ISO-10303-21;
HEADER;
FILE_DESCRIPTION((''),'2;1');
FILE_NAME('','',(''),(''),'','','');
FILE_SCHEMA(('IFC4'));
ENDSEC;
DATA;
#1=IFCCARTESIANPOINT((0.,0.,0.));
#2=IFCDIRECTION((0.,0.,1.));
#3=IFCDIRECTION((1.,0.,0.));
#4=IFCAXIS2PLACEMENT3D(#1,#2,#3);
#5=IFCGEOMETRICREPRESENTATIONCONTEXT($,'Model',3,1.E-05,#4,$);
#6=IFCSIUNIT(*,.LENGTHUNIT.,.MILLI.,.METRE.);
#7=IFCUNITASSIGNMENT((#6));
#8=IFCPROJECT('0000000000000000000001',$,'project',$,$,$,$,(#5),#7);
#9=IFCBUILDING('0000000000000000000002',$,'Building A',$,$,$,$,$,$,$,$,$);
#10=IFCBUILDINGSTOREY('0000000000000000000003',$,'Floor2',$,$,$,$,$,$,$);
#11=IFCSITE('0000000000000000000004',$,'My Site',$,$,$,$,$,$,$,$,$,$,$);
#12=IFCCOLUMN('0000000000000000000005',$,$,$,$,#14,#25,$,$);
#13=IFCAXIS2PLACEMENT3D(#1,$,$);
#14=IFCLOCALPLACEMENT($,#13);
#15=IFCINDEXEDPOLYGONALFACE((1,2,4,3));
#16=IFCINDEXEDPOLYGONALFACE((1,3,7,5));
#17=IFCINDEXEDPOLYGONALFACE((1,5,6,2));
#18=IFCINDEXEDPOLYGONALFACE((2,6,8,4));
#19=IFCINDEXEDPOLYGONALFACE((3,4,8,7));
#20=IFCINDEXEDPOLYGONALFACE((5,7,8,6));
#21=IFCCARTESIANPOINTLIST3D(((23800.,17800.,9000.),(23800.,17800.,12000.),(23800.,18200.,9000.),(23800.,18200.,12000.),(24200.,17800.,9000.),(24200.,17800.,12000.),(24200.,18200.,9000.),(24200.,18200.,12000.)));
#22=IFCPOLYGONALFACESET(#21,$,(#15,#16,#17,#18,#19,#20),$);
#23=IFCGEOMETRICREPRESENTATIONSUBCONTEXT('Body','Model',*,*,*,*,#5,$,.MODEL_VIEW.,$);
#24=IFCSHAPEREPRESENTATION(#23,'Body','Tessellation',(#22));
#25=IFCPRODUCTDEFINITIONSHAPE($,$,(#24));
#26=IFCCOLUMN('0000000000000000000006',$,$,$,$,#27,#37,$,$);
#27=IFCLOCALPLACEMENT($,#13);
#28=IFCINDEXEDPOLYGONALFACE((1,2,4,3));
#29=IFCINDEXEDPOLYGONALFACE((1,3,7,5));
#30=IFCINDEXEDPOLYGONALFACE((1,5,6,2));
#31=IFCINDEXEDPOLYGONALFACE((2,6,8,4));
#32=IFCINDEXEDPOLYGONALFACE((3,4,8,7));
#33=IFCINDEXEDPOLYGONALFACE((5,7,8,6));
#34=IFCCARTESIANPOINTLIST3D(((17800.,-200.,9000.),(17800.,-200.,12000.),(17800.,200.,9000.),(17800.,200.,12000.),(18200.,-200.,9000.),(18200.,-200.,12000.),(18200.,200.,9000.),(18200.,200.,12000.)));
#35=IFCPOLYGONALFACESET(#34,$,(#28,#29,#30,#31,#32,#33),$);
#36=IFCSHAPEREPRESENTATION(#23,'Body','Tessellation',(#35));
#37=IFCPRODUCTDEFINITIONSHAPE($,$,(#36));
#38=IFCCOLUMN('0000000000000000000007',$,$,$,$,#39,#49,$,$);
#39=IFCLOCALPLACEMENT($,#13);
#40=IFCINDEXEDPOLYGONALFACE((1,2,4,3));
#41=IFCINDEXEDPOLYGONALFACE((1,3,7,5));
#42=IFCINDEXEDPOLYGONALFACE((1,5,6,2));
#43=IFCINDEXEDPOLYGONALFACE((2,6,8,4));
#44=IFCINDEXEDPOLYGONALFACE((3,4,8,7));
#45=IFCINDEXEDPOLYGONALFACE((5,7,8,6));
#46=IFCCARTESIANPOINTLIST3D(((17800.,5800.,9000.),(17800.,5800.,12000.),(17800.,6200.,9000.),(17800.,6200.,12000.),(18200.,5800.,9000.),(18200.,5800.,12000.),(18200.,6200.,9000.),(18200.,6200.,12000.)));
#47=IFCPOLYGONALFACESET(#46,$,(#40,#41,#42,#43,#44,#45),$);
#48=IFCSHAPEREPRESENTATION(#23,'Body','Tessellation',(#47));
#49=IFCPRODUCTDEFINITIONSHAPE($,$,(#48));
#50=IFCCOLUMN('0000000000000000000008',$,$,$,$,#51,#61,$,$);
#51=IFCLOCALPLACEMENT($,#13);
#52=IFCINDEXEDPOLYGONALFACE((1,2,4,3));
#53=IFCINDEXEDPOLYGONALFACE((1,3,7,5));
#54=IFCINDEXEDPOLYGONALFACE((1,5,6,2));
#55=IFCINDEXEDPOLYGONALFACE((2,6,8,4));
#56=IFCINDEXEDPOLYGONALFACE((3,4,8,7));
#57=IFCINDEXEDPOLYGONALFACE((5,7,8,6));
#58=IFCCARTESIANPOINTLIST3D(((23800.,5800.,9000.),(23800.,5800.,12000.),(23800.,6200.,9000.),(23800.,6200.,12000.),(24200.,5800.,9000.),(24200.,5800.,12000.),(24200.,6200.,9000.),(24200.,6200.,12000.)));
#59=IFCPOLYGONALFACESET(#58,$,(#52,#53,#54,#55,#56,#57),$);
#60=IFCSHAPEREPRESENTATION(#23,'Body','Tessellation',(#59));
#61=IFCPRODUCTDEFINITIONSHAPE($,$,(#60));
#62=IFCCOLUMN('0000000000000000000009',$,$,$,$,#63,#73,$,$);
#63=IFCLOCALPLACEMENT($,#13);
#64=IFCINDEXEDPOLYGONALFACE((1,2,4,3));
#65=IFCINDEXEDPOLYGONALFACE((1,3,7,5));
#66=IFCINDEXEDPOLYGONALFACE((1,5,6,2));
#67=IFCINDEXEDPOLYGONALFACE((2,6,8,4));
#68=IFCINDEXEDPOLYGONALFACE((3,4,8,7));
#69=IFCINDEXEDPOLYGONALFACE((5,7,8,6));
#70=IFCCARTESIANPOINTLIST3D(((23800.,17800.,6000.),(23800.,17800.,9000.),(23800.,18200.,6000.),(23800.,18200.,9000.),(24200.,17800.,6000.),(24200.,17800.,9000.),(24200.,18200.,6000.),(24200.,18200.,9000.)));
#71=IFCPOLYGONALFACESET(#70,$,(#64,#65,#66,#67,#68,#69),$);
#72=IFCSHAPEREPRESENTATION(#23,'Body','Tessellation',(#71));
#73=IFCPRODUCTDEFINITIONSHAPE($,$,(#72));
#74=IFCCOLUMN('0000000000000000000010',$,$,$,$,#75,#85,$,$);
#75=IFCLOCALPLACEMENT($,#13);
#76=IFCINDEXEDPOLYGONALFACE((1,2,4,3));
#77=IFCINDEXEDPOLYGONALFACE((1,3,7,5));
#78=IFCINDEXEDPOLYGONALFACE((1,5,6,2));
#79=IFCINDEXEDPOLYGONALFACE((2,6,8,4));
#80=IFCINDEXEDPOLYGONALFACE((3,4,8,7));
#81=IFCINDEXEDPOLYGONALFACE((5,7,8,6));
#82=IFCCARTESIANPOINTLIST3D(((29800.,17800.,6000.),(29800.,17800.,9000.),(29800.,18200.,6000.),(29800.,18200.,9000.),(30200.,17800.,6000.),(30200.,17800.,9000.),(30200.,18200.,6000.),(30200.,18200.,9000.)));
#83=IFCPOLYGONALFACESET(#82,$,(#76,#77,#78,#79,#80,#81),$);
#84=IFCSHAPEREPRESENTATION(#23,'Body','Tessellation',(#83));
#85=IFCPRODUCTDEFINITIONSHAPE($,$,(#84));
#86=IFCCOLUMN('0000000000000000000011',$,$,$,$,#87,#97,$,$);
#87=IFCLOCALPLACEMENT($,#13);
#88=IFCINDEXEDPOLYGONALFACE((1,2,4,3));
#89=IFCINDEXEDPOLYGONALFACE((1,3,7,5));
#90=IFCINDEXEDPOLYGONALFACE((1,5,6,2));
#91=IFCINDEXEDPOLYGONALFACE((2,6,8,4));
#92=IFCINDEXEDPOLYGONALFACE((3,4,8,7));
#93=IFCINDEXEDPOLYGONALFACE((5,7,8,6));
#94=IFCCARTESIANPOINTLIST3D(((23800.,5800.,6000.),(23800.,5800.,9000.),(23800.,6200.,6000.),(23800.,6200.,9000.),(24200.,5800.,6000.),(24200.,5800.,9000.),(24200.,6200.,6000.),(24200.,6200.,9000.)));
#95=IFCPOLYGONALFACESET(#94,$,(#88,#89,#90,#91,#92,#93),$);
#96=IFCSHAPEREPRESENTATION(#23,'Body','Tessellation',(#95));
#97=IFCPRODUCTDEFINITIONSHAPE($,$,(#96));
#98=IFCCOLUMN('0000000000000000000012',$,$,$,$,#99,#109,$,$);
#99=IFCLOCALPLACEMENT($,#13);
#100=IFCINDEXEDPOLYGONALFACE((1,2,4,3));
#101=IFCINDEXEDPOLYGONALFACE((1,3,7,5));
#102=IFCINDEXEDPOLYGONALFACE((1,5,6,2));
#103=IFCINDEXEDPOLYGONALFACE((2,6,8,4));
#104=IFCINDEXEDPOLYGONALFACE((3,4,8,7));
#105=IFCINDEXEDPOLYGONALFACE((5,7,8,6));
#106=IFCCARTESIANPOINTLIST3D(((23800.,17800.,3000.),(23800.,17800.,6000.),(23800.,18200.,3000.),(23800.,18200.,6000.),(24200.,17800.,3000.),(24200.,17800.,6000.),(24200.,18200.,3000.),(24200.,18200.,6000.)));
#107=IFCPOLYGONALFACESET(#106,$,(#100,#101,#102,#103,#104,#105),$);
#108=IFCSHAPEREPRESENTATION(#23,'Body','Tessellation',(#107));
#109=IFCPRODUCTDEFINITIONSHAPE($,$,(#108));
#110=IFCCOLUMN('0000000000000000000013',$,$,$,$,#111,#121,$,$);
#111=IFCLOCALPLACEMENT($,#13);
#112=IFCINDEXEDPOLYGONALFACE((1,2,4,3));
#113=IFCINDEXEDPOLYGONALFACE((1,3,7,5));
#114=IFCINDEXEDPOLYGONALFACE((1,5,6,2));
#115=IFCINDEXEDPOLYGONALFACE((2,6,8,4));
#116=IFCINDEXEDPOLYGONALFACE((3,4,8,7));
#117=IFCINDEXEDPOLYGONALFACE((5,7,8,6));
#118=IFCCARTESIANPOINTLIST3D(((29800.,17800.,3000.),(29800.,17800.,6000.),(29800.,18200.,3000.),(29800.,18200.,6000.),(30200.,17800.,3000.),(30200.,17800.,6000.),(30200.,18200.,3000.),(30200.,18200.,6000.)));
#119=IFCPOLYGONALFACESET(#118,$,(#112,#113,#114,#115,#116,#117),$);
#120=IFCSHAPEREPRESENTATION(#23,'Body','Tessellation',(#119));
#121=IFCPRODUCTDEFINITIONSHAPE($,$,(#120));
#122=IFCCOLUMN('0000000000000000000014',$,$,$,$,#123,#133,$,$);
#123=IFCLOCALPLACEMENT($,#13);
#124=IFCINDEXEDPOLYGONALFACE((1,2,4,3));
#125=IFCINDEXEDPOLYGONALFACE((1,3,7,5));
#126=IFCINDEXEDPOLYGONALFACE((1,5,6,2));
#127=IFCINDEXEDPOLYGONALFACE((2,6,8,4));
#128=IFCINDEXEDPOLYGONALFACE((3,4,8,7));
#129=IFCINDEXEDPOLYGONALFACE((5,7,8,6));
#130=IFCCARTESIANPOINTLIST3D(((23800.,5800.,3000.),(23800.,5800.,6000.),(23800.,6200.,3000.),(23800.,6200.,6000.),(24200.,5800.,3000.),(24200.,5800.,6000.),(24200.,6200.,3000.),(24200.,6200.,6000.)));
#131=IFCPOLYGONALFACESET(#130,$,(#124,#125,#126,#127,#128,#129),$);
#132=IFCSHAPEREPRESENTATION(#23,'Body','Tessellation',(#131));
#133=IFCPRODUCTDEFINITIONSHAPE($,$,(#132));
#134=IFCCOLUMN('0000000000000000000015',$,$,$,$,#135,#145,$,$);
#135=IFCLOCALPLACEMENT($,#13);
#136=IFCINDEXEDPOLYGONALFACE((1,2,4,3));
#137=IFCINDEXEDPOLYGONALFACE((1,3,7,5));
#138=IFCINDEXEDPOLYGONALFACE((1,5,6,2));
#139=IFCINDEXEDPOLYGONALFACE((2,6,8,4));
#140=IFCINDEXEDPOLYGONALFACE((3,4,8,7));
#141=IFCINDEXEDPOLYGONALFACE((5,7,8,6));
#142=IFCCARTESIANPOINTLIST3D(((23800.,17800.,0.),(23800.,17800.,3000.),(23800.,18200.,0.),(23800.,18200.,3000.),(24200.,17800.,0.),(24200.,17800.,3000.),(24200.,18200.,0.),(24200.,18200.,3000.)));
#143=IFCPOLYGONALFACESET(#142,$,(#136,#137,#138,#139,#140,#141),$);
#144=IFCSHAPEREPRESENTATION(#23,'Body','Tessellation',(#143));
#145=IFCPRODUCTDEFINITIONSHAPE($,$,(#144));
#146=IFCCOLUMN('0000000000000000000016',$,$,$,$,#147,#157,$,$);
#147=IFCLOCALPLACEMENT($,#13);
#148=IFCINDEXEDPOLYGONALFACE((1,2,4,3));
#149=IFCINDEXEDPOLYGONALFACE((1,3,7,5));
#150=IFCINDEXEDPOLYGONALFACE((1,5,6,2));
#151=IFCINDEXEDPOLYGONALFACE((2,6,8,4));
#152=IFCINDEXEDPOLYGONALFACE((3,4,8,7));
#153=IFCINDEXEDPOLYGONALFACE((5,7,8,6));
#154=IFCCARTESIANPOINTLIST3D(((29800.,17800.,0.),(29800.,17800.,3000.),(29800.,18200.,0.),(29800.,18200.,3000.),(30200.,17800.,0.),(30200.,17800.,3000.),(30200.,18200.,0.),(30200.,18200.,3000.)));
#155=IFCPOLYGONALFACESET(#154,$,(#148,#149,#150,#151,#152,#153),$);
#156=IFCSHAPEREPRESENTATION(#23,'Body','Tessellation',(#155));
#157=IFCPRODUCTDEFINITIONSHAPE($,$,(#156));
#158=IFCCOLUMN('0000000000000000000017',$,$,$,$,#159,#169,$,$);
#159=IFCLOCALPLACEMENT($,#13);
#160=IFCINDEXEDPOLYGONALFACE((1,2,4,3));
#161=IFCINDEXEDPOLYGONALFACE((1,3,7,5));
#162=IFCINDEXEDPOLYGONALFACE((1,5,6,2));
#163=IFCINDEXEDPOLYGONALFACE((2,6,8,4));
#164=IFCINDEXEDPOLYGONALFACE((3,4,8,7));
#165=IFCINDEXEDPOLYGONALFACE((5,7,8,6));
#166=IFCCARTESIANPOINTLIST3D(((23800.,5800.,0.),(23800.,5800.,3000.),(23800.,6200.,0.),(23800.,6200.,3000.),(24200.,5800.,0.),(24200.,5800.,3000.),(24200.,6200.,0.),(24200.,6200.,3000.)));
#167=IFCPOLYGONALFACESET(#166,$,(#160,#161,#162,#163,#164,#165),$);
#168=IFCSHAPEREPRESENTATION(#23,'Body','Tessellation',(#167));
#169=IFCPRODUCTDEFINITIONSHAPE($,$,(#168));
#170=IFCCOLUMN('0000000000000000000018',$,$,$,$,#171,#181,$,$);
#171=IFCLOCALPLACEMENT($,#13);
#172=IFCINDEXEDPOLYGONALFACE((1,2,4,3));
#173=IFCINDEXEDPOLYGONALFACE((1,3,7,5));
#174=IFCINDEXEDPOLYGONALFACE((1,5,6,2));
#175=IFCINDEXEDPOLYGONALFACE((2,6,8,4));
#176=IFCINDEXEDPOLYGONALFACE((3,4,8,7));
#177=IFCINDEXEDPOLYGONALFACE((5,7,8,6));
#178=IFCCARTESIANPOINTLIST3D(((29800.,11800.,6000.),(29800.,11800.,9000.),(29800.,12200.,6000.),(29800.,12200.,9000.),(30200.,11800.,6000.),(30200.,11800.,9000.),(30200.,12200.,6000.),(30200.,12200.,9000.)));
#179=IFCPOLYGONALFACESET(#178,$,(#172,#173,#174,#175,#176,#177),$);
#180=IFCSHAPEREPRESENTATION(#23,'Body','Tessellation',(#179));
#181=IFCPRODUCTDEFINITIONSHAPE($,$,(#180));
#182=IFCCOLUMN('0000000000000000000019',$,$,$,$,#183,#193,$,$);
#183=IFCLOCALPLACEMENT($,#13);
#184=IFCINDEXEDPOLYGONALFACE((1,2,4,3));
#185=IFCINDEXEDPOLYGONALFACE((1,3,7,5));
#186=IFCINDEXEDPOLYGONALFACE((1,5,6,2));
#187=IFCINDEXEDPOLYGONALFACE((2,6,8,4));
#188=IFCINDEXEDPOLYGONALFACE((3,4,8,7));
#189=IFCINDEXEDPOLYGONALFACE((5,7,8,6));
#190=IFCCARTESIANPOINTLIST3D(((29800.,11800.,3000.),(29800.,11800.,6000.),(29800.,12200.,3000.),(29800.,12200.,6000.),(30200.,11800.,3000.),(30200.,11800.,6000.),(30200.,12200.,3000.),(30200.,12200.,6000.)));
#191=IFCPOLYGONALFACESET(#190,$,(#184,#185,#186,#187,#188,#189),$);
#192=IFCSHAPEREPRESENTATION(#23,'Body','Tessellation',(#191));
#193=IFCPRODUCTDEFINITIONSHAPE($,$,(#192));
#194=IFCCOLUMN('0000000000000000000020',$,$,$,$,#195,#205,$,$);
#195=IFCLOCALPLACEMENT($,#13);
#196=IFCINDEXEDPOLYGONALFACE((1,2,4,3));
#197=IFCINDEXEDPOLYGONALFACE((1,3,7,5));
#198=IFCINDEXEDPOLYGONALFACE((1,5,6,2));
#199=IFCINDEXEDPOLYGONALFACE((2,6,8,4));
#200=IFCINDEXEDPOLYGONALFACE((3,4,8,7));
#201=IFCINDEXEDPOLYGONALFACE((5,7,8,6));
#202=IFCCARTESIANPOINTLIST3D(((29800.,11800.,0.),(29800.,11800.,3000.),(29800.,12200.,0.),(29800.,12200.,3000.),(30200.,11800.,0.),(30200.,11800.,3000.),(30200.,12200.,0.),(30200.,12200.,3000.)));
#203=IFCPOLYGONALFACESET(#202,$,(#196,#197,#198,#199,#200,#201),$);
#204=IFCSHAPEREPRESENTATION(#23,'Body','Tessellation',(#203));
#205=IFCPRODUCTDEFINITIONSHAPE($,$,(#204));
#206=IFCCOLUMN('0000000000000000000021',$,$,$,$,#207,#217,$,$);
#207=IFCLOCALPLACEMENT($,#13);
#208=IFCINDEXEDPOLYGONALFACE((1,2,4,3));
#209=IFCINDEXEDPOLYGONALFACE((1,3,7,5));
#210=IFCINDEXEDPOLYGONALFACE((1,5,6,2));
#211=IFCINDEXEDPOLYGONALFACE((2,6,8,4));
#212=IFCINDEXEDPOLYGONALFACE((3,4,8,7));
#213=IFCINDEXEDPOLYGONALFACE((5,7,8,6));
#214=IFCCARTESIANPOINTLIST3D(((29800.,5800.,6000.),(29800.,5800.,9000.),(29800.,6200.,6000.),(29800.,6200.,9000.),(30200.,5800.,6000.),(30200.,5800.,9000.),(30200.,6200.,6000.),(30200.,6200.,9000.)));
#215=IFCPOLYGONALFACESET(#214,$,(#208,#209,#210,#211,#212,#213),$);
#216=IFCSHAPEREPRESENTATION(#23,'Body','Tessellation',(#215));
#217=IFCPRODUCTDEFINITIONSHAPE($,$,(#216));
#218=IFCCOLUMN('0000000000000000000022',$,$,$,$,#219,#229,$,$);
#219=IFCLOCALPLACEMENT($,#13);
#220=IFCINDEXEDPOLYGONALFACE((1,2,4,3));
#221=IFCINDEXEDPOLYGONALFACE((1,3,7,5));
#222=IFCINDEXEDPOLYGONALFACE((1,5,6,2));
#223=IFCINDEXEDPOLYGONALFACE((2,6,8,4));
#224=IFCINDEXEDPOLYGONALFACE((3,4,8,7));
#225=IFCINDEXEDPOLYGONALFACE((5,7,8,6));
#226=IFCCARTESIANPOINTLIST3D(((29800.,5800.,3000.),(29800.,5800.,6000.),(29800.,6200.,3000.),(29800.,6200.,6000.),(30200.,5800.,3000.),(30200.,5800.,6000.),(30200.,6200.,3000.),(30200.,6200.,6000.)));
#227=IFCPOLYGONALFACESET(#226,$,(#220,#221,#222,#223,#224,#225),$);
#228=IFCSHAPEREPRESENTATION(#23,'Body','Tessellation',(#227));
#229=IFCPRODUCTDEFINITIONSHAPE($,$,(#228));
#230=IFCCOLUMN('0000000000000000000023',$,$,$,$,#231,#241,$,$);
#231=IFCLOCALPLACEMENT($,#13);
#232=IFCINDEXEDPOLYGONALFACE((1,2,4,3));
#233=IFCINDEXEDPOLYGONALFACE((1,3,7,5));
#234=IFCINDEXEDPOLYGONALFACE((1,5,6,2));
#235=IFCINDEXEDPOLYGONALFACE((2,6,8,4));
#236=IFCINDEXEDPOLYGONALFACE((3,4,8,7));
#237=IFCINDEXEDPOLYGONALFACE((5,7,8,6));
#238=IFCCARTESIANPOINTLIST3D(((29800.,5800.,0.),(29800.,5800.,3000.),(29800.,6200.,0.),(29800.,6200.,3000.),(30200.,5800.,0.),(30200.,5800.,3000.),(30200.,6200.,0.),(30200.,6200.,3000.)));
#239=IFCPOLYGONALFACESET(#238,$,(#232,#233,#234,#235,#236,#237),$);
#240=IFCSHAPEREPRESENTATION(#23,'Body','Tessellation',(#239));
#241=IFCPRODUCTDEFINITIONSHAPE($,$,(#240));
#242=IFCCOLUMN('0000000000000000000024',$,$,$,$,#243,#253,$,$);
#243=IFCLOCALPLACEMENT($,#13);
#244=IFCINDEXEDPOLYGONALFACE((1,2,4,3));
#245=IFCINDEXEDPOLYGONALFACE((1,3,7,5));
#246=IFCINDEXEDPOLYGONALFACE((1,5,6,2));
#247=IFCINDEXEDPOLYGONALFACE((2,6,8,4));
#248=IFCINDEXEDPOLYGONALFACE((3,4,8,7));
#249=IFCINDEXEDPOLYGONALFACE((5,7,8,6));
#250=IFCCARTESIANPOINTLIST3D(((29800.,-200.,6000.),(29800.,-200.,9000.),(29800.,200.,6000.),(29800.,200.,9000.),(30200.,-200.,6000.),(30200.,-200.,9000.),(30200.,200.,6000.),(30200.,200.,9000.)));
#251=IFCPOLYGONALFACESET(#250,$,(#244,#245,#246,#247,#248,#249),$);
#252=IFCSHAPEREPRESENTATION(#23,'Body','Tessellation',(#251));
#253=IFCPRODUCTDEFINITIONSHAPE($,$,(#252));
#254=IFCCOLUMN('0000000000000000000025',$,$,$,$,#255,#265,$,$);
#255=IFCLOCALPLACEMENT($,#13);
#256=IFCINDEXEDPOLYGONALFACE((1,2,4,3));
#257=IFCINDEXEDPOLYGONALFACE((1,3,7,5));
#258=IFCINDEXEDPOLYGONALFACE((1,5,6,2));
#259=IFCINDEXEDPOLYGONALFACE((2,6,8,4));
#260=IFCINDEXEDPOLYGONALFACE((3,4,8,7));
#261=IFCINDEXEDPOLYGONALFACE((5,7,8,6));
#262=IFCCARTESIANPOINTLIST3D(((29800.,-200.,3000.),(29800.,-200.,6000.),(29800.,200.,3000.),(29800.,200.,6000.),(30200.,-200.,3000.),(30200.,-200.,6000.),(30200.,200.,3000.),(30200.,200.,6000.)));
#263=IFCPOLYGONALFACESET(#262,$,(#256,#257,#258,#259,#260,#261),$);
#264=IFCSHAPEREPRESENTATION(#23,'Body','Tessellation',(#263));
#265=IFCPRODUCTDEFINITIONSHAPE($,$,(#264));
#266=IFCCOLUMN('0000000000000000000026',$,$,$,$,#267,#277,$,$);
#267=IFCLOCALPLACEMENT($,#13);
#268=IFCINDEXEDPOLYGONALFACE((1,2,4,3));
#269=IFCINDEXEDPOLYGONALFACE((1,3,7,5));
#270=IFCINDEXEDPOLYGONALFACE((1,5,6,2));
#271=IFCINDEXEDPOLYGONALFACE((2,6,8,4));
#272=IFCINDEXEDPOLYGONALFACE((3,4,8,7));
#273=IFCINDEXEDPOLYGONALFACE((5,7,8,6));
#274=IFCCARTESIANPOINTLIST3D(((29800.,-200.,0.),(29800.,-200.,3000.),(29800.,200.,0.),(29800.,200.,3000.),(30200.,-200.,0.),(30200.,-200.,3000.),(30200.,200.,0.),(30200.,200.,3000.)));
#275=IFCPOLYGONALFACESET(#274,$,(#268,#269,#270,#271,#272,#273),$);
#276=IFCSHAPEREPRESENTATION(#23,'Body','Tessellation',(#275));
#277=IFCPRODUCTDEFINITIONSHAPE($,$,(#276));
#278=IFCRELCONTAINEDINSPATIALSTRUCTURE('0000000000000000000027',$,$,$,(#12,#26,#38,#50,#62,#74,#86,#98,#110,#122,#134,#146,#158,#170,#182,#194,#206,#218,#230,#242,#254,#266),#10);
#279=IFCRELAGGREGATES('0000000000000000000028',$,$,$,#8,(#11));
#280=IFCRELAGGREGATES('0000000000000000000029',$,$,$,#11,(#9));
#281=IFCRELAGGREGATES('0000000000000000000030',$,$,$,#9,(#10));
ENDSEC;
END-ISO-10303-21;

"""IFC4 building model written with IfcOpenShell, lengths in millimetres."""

from ifc_helpers import new_model, si_unit, frame, origin_with_axes, place, context, subcontext, project, spatial, line, indexed_curve, outline, extrude, element, save


model = new_model("IFC4")

# Units and contexts
model_context = context("Model", 3, precision=1e-05, world=origin_with_axes())
body_context = subcontext(model_context, "Body", "Model", "MODEL_VIEW")
ifc_project = project(units=[si_unit("LENGTHUNIT", "METRE", prefix="MILLI")], contexts=[model_context])

# Site, building, storey
site = spatial("IfcSite", under=ifc_project, Name="My Site")
building = spatial("IfcBuilding", under=site, Name="Building A")
storey = spatial("IfcBuildingStorey", under=building, Name="Floor2")

# Columns
for number, where, z_axis, x_axis in (
    (1, (24000.0, 18000.0, 9000.0), (0.0, 0.0, 1.0), (1.0, 0.0, 0.0)),
    (2, (18000.0, 0.0, 9000.0), (0.0, 0.0, 1.0), (1.0, 0.0, 0.0)),
    (3, (18000.0, 6000.0, 9000.0), (0.0, 0.0, 1.0), (1.0, 0.0, 0.0)),
    (4, (24000.0, 6000.0, 9000.0), (0.0, 0.0, 1.0), (1.0, 0.0, 0.0)),
    (5, (24000.0, 18000.0, 6000.0), (0.0, 0.0, 1.0), (1.0, 0.0, 0.0)),
    (6, (30000.0, 18000.0, 6000.0), (0.0, 0.0, 1.0), (1.0, 0.0, 0.0)),
    (7, (24000.0, 6000.0, 6000.0), (0.0, 0.0, 1.0), (1.0, 0.0, 0.0)),
    (8, (24000.0, 18000.0, 3000.0), (0.0, 0.0, 1.0), (1.0, 0.0, 0.0)),
    (9, (30000.0, 18000.0, 3000.0), (0.0, 0.0, 1.0), (1.0, 0.0, 0.0)),
    (10, (24000.0, 6000.0, 3000.0), (0.0, 0.0, 1.0), (1.0, 0.0, 0.0)),
    (11, (24000.0, 18000.0, 0.0), (0.0, 0.0, 1.0), (1.0, 0.0, 0.0)),
    (12, (30000.0, 18000.0, 0.0), (0.0, 0.0, 1.0), (1.0, 0.0, 0.0)),
    (13, (24000.0, 6000.0, 0.0), (0.0, 0.0, 1.0), (1.0, 0.0, 0.0)),
    (14, (30000.0, 12000.0, 6000.0), (0.0, 0.0, 1.0), (1.0, 0.0, 0.0)),
    (15, (30000.0, 12000.0, 3000.0), (0.0, 0.0, 1.0), (1.0, 0.0, 0.0)),
    (16, (30000.0, 12000.0, 0.0), (0.0, 0.0, 1.0), (1.0, 0.0, 0.0)),
    (17, (30000.0, 6000.0, 6000.0), (0.0, 0.0, 1.0), (1.0, 0.0, 0.0)),
    (18, (30000.0, 6000.0, 3000.0), (0.0, 0.0, 1.0), (1.0, 0.0, 0.0)),
    (19, (30000.0, 6000.0, 0.0), (0.0, 0.0, 1.0), (1.0, 0.0, 0.0)),
    (20, (30000.0, 0.0, 6000.0), (0.0, 0.0, 1.0), (1.0, 0.0, 0.0)),
    (21, (30000.0, 0.0, 3000.0), (0.0, 0.0, 1.0), (1.0, 0.0, 0.0)),
    (22, (30000.0, 0.0, 0.0), (0.0, 0.0, 1.0), (1.0, 0.0, 0.0)),
):
    element("IfcColumn", number, at=place(None, frame(where, z_axis=z_axis, x_axis=x_axis)), inside=storey, context=body_context, shape_type="SweptSolid", body=[
        extrude(outline(indexed_curve([(-200.0, -200.0), (200.0, -200.0), (200.0, 200.0), (-200.0, 200.0)], segments=[line(1, 2, 3, 4, 1)])), origin_with_axes(), (0.0, 0.0, 1.0), 3000.0),
    ])

save(model, "model.ifc")
